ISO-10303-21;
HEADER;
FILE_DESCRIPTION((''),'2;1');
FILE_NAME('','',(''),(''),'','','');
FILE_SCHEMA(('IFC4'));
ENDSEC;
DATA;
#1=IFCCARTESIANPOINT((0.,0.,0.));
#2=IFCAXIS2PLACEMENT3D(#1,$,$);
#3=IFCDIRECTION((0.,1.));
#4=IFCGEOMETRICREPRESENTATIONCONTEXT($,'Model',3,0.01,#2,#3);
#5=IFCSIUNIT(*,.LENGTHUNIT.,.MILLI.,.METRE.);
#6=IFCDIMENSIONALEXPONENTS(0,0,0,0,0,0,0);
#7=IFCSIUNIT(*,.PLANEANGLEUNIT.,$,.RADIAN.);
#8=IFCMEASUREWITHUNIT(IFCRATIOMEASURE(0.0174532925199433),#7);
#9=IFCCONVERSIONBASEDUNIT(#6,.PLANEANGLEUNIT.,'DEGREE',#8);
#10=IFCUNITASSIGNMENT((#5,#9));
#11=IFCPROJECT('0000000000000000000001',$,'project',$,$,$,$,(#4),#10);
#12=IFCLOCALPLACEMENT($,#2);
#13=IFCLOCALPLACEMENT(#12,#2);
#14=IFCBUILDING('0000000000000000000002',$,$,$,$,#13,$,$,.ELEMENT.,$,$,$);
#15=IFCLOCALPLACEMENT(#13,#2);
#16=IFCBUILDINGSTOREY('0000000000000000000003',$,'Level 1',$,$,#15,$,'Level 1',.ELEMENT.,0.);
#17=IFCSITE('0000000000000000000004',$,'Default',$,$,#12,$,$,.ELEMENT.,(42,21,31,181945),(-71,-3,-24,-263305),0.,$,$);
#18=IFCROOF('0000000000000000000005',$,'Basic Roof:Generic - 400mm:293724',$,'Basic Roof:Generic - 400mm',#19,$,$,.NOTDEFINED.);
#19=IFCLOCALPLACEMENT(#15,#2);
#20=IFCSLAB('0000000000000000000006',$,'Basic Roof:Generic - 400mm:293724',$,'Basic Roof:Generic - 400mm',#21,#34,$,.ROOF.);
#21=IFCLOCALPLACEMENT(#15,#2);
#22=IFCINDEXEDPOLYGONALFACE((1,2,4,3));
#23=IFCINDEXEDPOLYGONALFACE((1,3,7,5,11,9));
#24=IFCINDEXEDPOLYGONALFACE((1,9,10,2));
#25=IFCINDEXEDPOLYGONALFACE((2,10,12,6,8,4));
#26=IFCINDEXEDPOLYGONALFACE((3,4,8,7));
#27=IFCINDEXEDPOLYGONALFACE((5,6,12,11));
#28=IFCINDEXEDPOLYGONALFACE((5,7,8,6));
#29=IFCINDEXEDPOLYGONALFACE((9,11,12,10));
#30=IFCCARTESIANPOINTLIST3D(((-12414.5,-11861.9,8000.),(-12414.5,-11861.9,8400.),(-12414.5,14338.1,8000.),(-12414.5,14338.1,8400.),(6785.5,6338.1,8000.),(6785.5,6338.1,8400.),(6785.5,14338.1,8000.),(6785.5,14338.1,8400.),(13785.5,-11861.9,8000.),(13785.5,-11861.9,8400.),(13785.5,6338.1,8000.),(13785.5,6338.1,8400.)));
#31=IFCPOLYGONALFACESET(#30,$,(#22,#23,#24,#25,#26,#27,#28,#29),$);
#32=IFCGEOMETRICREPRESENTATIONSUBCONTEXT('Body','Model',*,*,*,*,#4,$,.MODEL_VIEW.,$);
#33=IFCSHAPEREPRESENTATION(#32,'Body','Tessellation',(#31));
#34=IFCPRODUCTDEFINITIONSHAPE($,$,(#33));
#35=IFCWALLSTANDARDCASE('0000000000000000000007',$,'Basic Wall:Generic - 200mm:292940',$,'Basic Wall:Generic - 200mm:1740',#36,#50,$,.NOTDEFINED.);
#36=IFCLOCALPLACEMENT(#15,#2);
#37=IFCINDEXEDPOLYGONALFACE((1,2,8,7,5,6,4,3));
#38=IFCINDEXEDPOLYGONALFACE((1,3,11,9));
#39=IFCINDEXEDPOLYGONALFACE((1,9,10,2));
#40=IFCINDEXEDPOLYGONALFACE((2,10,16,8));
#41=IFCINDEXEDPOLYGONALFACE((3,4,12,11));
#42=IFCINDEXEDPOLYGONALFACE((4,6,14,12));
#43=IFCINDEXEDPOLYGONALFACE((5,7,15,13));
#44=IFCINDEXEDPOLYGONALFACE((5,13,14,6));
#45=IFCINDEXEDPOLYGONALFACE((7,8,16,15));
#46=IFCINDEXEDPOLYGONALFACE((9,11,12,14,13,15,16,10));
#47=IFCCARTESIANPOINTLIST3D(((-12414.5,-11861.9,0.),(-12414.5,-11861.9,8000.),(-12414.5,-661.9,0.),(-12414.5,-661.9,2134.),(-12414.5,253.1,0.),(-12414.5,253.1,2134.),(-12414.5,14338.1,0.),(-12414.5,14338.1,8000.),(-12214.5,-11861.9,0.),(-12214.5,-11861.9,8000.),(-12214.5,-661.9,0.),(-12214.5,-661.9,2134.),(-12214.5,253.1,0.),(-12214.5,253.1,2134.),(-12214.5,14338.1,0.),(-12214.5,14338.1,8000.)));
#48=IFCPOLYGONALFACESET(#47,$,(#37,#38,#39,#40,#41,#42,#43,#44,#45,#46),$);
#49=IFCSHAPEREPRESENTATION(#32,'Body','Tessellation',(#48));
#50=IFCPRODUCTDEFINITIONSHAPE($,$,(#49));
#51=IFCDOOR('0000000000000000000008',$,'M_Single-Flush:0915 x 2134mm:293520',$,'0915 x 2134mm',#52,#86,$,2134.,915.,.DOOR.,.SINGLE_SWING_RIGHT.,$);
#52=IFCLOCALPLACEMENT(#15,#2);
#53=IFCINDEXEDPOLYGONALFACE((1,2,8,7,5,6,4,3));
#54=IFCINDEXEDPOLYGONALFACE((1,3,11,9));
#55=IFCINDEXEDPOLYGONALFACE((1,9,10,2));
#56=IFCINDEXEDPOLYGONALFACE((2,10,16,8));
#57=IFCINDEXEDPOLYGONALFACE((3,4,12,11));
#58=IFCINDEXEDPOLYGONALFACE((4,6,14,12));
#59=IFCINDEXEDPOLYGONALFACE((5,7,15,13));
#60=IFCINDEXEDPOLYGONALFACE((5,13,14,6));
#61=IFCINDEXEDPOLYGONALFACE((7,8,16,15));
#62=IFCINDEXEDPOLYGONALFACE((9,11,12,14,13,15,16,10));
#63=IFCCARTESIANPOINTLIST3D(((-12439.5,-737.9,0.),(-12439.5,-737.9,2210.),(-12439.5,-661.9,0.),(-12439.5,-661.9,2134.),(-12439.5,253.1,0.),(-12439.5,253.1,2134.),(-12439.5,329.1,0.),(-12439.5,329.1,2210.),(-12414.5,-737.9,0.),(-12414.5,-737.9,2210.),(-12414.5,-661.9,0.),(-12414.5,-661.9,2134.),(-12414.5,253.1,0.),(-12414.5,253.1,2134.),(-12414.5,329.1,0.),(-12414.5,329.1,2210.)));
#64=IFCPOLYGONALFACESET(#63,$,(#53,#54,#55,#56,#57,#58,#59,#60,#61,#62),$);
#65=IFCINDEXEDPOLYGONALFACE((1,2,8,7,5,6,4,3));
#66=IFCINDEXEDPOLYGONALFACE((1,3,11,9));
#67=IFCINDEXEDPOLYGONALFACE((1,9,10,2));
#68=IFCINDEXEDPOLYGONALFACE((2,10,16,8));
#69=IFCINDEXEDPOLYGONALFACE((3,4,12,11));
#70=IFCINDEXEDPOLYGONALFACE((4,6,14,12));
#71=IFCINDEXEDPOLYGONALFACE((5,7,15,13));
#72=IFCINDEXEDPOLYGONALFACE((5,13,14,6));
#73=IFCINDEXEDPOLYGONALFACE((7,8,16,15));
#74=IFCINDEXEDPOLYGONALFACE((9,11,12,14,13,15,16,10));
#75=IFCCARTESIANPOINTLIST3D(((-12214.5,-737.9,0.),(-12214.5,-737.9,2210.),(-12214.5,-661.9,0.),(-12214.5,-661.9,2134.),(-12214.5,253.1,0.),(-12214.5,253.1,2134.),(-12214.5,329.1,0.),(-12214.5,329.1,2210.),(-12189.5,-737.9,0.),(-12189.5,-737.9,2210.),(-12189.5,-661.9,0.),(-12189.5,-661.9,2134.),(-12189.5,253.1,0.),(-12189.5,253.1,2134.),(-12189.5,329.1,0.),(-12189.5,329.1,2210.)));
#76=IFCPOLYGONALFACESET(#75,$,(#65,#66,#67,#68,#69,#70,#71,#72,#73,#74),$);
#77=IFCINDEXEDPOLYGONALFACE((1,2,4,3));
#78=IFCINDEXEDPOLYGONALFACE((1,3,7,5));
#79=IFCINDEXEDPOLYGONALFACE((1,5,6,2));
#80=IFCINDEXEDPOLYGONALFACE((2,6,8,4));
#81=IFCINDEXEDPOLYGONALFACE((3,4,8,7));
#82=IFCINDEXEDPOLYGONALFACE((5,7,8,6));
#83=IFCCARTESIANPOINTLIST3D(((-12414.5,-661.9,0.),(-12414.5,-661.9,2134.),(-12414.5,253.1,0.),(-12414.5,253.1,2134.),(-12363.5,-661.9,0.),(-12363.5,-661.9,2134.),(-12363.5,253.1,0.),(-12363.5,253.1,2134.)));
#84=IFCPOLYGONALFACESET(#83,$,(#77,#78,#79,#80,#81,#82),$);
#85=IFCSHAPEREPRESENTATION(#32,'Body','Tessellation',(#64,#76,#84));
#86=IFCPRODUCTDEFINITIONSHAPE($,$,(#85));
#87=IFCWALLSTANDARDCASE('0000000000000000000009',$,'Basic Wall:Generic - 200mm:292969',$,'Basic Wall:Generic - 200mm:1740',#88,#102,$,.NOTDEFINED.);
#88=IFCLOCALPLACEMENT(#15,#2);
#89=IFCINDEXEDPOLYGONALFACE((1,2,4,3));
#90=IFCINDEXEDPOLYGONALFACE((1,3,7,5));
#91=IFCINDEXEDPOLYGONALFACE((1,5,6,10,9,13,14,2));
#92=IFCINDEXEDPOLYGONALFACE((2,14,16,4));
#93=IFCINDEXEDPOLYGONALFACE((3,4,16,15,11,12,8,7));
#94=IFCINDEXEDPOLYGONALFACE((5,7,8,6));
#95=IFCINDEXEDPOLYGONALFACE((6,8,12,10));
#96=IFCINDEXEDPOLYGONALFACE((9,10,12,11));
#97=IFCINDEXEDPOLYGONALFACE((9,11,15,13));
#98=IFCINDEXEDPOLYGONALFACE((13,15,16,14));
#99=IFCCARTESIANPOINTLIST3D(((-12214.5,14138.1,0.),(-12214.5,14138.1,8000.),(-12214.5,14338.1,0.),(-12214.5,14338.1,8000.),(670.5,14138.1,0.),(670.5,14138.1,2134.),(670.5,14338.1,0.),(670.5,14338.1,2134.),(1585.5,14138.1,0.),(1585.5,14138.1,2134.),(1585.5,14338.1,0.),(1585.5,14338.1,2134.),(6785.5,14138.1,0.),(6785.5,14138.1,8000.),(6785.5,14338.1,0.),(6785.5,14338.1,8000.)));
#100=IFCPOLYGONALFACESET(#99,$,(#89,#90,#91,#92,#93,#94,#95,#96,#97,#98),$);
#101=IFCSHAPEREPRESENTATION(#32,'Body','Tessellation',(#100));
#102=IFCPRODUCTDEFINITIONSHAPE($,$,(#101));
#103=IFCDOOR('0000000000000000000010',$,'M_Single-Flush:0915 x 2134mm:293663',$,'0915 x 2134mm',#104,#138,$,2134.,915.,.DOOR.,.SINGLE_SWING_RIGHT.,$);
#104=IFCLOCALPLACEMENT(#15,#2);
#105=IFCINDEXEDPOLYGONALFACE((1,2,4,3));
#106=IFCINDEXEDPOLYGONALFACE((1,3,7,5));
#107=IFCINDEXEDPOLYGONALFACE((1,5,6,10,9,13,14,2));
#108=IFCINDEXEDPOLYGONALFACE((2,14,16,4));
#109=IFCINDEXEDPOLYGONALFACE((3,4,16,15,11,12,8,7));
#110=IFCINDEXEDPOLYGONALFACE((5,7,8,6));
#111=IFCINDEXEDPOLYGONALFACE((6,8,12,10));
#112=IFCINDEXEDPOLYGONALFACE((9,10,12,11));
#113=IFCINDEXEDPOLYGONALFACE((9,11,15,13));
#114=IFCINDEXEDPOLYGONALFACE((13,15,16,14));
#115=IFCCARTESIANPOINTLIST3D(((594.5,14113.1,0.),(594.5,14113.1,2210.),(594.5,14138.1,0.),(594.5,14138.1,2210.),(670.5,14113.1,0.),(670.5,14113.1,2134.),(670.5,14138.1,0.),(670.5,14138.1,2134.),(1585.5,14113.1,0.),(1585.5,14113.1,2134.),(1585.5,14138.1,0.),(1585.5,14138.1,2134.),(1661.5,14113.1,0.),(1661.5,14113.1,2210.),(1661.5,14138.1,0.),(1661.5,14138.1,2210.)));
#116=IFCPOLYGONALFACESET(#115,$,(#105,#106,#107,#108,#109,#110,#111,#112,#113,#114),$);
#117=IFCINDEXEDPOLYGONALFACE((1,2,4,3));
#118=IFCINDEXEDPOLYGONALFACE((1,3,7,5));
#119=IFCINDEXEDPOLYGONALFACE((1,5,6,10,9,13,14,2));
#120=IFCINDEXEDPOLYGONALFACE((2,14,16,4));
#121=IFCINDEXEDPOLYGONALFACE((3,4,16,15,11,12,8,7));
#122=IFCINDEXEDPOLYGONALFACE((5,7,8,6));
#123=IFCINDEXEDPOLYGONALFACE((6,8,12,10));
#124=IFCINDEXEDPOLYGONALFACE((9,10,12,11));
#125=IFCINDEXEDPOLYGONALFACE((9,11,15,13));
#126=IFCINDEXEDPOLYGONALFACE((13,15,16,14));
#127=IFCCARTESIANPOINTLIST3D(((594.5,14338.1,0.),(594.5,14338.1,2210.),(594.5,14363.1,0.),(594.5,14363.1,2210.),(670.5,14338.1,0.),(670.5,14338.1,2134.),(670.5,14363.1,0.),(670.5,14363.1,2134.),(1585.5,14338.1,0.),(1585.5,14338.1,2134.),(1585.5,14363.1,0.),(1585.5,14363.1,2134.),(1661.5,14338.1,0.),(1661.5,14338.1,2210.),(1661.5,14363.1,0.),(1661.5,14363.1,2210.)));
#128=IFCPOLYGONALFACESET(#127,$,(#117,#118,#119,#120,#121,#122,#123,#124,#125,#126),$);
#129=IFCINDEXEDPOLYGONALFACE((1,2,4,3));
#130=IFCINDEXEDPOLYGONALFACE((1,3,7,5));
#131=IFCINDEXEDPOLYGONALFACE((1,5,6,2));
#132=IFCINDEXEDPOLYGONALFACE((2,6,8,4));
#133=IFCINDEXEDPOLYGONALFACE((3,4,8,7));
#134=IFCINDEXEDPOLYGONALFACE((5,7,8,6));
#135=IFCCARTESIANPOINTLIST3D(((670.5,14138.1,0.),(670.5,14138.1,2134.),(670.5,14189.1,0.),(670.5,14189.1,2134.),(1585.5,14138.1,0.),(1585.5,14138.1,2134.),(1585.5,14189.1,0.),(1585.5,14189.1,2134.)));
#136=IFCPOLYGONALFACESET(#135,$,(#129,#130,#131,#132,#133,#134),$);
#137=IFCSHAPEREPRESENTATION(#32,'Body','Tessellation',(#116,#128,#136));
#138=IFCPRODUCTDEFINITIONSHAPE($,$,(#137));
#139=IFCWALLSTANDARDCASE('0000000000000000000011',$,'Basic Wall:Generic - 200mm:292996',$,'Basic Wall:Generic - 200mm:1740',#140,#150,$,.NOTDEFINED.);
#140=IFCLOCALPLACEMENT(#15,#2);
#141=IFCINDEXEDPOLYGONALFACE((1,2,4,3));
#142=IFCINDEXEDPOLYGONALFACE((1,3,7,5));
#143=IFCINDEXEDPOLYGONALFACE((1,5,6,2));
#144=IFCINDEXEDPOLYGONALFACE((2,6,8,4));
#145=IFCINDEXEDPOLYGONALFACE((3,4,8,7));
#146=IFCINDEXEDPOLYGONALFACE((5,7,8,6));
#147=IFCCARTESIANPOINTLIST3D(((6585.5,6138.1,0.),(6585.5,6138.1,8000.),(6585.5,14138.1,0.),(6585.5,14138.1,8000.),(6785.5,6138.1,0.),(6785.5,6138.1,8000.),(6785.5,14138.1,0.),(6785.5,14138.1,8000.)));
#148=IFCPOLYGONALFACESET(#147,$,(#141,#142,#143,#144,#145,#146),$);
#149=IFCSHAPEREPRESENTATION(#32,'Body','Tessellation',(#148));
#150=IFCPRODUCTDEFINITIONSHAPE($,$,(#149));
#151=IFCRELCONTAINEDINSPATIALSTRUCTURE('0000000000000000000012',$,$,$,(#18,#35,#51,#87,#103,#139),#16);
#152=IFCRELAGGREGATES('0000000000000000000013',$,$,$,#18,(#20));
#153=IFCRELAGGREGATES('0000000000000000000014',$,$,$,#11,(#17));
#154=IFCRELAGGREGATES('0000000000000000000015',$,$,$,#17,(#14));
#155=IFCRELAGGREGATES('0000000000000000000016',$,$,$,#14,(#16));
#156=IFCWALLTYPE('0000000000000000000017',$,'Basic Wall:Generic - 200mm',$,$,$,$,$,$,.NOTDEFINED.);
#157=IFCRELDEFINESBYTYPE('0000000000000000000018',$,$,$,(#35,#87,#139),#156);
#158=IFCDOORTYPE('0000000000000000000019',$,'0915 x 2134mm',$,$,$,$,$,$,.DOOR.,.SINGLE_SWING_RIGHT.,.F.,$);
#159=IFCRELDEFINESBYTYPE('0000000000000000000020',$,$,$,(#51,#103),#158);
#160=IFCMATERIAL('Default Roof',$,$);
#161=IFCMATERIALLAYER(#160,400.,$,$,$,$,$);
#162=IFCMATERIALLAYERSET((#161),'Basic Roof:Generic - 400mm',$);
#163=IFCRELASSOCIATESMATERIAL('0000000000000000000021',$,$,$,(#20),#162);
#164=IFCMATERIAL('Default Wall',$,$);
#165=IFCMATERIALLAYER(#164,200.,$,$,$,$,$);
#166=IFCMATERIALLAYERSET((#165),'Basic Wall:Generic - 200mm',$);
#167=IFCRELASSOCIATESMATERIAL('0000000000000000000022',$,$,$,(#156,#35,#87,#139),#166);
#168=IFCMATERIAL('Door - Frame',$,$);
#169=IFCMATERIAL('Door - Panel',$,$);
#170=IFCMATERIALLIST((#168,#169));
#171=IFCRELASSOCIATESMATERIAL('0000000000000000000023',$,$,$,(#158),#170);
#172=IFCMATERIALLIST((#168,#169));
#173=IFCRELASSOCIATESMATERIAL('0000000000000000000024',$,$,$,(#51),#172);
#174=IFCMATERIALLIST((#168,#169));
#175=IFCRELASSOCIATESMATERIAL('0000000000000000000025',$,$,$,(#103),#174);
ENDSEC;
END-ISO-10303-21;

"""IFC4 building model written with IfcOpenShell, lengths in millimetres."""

from ifc_helpers import new_model, entity, si_unit, converted_unit, direction, frame, frame_2d, origin, place, context, subcontext, project, spatial, polyline, rectangle, outline, extrude, source, transform, mapped, material, material_list, layer, layer_set, layer_usage, type_object, type_shapes, element, fill, aggregate, save


model = new_model("IFC4")

# Units and contexts
model_context = context("Model", 3, precision=0.01, world=origin(), true_north=direction((0.0, 1.0)))
body_context = subcontext(model_context, "Body", "Model", "MODEL_VIEW")
ifc_project = project(units=[si_unit("LENGTHUNIT", "METRE", prefix="MILLI"), converted_unit("PLANEANGLEUNIT", "DEGREE", entity("IfcRatioMeasure", 0.0174532925199433), si_unit("PLANEANGLEUNIT", "RADIAN"), dimensions=[0, 0, 0, 0, 0, 0, 0])], contexts=[model_context])

# Site, building, storey
site_placement = place(None, origin())
site = spatial("IfcSite", under=ifc_project, at=site_placement, Name="Default", CompositionType="ELEMENT", RefLatitude=(42, 21, 31, 181945), RefLongitude=(-71, -3, -24, -263305), RefElevation=0.0)
building_placement = place(site_placement, origin())
building = spatial("IfcBuilding", under=site, at=building_placement, CompositionType="ELEMENT")
storey_placement = place(building_placement, origin())
storey = spatial("IfcBuildingStorey", under=building, at=storey_placement, Name="Level 1", LongName="Level 1", CompositionType="ELEMENT", Elevation=0.0)

# Roof, slab
roof_placement = place(storey_placement, frame((-12414.5, -11861.9, 8000.0)))
roof = element("IfcRoof", 1, at=roof_placement, inside=storey, Name="Basic Roof:Generic - 400mm:293724", ObjectType="Basic Roof:Generic - 400mm", PredefinedType="NOTDEFINED")
ifc_material_1 = material(Name="Default Roof")
ifc_layer_1 = layer(ifc_material_1, 400.0)
ifc_layer_set_1 = layer_set([ifc_layer_1], Name="Basic Roof:Generic - 400mm")
slab_1_placement = place(roof_placement, origin())
slab_1 = element("IfcSlab", 2, at=slab_1_placement, material=ifc_layer_set_1, Name="Basic Roof:Generic - 400mm:293724", ObjectType="Basic Roof:Generic - 400mm", PredefinedType="ROOF", context=body_context, shape_type="SweptSolid", body=[
    extrude(outline(polyline([(-13100.0, 13100.0), (-13100.0, -13100.0), (13100.0, -13100.0), (13100.0, 5100.0), (6100.0, 5100.0), (6100.0, 13100.0), (-13100.0, 13100.0)])), frame((13100.0, 13100.0, 0.0)), (0.0, 0.0, 1.0), 400.0),
])
aggregate(roof, [slab_1])

# Walls, openings, doors
ifc_material_2 = material(Name="Default Wall")
ifc_layer_2 = layer(ifc_material_2, 200.0)
ifc_layer_set_2 = layer_set([ifc_layer_2], Name="Basic Wall:Generic - 200mm")
ifc_layer_usage_1 = layer_usage(ifc_layer_set_2, "AXIS2", "NEGATIVE", 100.0)
wall_type = type_object("IfcWallType", Name="Basic Wall:Generic - 200mm", PredefinedType="NOTDEFINED", material=ifc_layer_set_2)
wall_1_placement = place(storey_placement, frame((-12314.5, -11861.9, 0.0), z_axis=(0.0, 0.0, 1.0), x_axis=(0.0, 1.0, 0.0)))
wall_1 = element("IfcWallStandardCase", 3, at=wall_1_placement, inside=storey, type_object=wall_type, material=ifc_layer_usage_1, Name="Basic Wall:Generic - 200mm:292940", ObjectType="Basic Wall:Generic - 200mm:1740", PredefinedType="NOTDEFINED", context=body_context, shape_type="SweptSolid", body=[
    extrude(rectangle(XDim=26200.0, YDim=200.0, at=frame_2d((13100.0, 0.0), x_axis=(-1.0, 0.0))), origin(), (0.0, 0.0, 1.0), 8000.0),
])
opening_1_placement = place(wall_1_placement, frame((11200.0, -100.0, 0.0)))
opening_1 = element("IfcOpeningElement", 4, at=opening_1_placement, cuts=wall_1, ObjectType="Opening", PredefinedType="OPENING", context=body_context, shape_type="SweptSolid", body=[
    extrude(rectangle(XDim=915.0, YDim=2134.0, at=frame_2d((1067.0, 457.5), x_axis=(0.0, 1.0))), frame((0.0, 0.0, 0.0), z_axis=(0.0, 1.0, 0.0), x_axis=(0.0, 0.0, 1.0)), (0.0, 0.0, 1.0), 200.0),
])
ifc_material_3 = material(Name="Door - Frame")
ifc_material_4 = material(Name="Door - Panel")
ifc_material_list_1 = material_list([ifc_material_3, ifc_material_4])
ifc_material_list_2 = material_list([ifc_material_3, ifc_material_4])
door_type = type_object("IfcDoorType", Name="0915 x 2134mm", OperationType="SINGLE_SWING_RIGHT", ParameterTakesPrecedence=False, PredefinedType="DOOR", material=ifc_material_list_2)
shared_shape = source(origin(), body_context, "Body", "SweptSolid", [
    extrude(outline(polyline([(-533.5, -1124.0), (533.5, -1124.0), (533.5, 1086.0), (457.5, 1086.0), (457.5, -1048.0), (-457.5, -1048.0), (-457.5, 1086.0), (-533.5, 1086.0), (-533.5, -1124.0)])), frame((457.5, 200.0, 1086.0), z_axis=(0.0, 1.0, 0.0), x_axis=(1.0, 0.0, 0.0)), (0.0, 0.0, 1.0), 25.0),
    extrude(outline(polyline([(-1124.0, -533.5), (1086.0, -533.5), (1086.0, -457.5), (-1048.0, -457.5), (-1048.0, 457.5), (1086.0, 457.5), (1086.0, 533.5), (-1124.0, 533.5), (-1124.0, -533.5)])), frame((457.5, -25.0, 1086.0), z_axis=(0.0, 1.0, 0.0), x_axis=(0.0, 0.0, -1.0)), (0.0, 0.0, 1.0), 25.0),
    extrude(rectangle(XDim=51.0, YDim=915.0, at=frame_2d((0.0, 0.0), x_axis=(1.0, 0.0))), frame((457.5, 174.5, 0.0), z_axis=(0.0, 0.0, 1.0), x_axis=(0.0, 1.0, 0.0)), (0.0, 0.0, 1.0), 2134.0),
])
type_shapes(door_type, [shared_shape])
door_1_placement = place(opening_1_placement, origin())
door_1 = element("IfcDoor", 5, at=door_1_placement, inside=storey, type_object=door_type, material=ifc_material_list_1, Name="M_Single-Flush:0915 x 2134mm:293520", ObjectType="0915 x 2134mm", OperationType="SINGLE_SWING_RIGHT", OverallHeight=2134.0, OverallWidth=915.0, PredefinedType="DOOR", context=body_context, shape_type="MappedRepresentation", body=[
    mapped(shared_shape, transform((0.0, 0.0, 0.0), scale=1.0)),
])
fill(opening_1, door_1)
ifc_layer_usage_2 = layer_usage(ifc_layer_set_2, "AXIS2", "NEGATIVE", 100.0)
wall_2_placement = place(storey_placement, frame((-12214.5, 14238.1, 0.0)))
wall_2 = element("IfcWallStandardCase", 6, at=wall_2_placement, inside=storey, type_object=wall_type, material=ifc_layer_usage_2, Name="Basic Wall:Generic - 200mm:292969", ObjectType="Basic Wall:Generic - 200mm:1740", PredefinedType="NOTDEFINED", context=body_context, shape_type="SweptSolid", body=[
    extrude(rectangle(XDim=19000.0, YDim=200.0, at=frame_2d((9500.0, 0.0), x_axis=(-1.0, 0.0))), origin(), (0.0, 0.0, 1.0), 8000.0),
])
opening_2_placement = place(wall_2_placement, frame((13800.0, 100.0, 0.0)))
opening_2 = element("IfcOpeningElement", 7, at=opening_2_placement, cuts=wall_2, ObjectType="Opening", PredefinedType="OPENING", context=body_context, shape_type="SweptSolid", body=[
    extrude(rectangle(XDim=915.0, YDim=2134.0, at=frame_2d((1067.0, 457.5), x_axis=(0.0, 1.0))), frame((0.0, 0.0, 0.0), z_axis=(0.0, -1.0, 0.0), x_axis=(0.0, 0.0, 1.0)), (0.0, 0.0, 1.0), 200.0),
])
ifc_material_list_3 = material_list([ifc_material_3, ifc_material_4])
door_2_placement = place(opening_2_placement, frame((0.0, 0.0, 0.0), z_axis=(0.0, 0.0, 1.0), x_axis=(-1.0, 0.0, 0.0)))
door_2 = element("IfcDoor", 8, at=door_2_placement, inside=storey, type_object=door_type, material=ifc_material_list_3, Name="M_Single-Flush:0915 x 2134mm:293663", ObjectType="0915 x 2134mm", OperationType="SINGLE_SWING_RIGHT", OverallHeight=2134.0, OverallWidth=915.0, PredefinedType="DOOR", context=body_context, shape_type="MappedRepresentation", body=[
    mapped(shared_shape, transform((0.0, 0.0, 0.0), scale=1.0)),
])
fill(opening_2, door_2)

# Wall
ifc_layer_usage_3 = layer_usage(ifc_layer_set_2, "AXIS2", "NEGATIVE", 100.0)
wall_3_placement = place(storey_placement, frame((6685.5, 14138.1, 0.0), z_axis=(0.0, 0.0, 1.0), x_axis=(0.0, -1.0, 0.0)))
element("IfcWallStandardCase", 9, at=wall_3_placement, inside=storey, type_object=wall_type, material=ifc_layer_usage_3, Name="Basic Wall:Generic - 200mm:292996", ObjectType="Basic Wall:Generic - 200mm:1740", PredefinedType="NOTDEFINED", context=body_context, shape_type="SweptSolid", body=[
    extrude(rectangle(XDim=8000.0, YDim=200.0, at=frame_2d((4000.0, 0.0), x_axis=(-1.0, 0.0))), origin(), (0.0, 0.0, 1.0), 8000.0),
])

save(model, "model.ifc")
